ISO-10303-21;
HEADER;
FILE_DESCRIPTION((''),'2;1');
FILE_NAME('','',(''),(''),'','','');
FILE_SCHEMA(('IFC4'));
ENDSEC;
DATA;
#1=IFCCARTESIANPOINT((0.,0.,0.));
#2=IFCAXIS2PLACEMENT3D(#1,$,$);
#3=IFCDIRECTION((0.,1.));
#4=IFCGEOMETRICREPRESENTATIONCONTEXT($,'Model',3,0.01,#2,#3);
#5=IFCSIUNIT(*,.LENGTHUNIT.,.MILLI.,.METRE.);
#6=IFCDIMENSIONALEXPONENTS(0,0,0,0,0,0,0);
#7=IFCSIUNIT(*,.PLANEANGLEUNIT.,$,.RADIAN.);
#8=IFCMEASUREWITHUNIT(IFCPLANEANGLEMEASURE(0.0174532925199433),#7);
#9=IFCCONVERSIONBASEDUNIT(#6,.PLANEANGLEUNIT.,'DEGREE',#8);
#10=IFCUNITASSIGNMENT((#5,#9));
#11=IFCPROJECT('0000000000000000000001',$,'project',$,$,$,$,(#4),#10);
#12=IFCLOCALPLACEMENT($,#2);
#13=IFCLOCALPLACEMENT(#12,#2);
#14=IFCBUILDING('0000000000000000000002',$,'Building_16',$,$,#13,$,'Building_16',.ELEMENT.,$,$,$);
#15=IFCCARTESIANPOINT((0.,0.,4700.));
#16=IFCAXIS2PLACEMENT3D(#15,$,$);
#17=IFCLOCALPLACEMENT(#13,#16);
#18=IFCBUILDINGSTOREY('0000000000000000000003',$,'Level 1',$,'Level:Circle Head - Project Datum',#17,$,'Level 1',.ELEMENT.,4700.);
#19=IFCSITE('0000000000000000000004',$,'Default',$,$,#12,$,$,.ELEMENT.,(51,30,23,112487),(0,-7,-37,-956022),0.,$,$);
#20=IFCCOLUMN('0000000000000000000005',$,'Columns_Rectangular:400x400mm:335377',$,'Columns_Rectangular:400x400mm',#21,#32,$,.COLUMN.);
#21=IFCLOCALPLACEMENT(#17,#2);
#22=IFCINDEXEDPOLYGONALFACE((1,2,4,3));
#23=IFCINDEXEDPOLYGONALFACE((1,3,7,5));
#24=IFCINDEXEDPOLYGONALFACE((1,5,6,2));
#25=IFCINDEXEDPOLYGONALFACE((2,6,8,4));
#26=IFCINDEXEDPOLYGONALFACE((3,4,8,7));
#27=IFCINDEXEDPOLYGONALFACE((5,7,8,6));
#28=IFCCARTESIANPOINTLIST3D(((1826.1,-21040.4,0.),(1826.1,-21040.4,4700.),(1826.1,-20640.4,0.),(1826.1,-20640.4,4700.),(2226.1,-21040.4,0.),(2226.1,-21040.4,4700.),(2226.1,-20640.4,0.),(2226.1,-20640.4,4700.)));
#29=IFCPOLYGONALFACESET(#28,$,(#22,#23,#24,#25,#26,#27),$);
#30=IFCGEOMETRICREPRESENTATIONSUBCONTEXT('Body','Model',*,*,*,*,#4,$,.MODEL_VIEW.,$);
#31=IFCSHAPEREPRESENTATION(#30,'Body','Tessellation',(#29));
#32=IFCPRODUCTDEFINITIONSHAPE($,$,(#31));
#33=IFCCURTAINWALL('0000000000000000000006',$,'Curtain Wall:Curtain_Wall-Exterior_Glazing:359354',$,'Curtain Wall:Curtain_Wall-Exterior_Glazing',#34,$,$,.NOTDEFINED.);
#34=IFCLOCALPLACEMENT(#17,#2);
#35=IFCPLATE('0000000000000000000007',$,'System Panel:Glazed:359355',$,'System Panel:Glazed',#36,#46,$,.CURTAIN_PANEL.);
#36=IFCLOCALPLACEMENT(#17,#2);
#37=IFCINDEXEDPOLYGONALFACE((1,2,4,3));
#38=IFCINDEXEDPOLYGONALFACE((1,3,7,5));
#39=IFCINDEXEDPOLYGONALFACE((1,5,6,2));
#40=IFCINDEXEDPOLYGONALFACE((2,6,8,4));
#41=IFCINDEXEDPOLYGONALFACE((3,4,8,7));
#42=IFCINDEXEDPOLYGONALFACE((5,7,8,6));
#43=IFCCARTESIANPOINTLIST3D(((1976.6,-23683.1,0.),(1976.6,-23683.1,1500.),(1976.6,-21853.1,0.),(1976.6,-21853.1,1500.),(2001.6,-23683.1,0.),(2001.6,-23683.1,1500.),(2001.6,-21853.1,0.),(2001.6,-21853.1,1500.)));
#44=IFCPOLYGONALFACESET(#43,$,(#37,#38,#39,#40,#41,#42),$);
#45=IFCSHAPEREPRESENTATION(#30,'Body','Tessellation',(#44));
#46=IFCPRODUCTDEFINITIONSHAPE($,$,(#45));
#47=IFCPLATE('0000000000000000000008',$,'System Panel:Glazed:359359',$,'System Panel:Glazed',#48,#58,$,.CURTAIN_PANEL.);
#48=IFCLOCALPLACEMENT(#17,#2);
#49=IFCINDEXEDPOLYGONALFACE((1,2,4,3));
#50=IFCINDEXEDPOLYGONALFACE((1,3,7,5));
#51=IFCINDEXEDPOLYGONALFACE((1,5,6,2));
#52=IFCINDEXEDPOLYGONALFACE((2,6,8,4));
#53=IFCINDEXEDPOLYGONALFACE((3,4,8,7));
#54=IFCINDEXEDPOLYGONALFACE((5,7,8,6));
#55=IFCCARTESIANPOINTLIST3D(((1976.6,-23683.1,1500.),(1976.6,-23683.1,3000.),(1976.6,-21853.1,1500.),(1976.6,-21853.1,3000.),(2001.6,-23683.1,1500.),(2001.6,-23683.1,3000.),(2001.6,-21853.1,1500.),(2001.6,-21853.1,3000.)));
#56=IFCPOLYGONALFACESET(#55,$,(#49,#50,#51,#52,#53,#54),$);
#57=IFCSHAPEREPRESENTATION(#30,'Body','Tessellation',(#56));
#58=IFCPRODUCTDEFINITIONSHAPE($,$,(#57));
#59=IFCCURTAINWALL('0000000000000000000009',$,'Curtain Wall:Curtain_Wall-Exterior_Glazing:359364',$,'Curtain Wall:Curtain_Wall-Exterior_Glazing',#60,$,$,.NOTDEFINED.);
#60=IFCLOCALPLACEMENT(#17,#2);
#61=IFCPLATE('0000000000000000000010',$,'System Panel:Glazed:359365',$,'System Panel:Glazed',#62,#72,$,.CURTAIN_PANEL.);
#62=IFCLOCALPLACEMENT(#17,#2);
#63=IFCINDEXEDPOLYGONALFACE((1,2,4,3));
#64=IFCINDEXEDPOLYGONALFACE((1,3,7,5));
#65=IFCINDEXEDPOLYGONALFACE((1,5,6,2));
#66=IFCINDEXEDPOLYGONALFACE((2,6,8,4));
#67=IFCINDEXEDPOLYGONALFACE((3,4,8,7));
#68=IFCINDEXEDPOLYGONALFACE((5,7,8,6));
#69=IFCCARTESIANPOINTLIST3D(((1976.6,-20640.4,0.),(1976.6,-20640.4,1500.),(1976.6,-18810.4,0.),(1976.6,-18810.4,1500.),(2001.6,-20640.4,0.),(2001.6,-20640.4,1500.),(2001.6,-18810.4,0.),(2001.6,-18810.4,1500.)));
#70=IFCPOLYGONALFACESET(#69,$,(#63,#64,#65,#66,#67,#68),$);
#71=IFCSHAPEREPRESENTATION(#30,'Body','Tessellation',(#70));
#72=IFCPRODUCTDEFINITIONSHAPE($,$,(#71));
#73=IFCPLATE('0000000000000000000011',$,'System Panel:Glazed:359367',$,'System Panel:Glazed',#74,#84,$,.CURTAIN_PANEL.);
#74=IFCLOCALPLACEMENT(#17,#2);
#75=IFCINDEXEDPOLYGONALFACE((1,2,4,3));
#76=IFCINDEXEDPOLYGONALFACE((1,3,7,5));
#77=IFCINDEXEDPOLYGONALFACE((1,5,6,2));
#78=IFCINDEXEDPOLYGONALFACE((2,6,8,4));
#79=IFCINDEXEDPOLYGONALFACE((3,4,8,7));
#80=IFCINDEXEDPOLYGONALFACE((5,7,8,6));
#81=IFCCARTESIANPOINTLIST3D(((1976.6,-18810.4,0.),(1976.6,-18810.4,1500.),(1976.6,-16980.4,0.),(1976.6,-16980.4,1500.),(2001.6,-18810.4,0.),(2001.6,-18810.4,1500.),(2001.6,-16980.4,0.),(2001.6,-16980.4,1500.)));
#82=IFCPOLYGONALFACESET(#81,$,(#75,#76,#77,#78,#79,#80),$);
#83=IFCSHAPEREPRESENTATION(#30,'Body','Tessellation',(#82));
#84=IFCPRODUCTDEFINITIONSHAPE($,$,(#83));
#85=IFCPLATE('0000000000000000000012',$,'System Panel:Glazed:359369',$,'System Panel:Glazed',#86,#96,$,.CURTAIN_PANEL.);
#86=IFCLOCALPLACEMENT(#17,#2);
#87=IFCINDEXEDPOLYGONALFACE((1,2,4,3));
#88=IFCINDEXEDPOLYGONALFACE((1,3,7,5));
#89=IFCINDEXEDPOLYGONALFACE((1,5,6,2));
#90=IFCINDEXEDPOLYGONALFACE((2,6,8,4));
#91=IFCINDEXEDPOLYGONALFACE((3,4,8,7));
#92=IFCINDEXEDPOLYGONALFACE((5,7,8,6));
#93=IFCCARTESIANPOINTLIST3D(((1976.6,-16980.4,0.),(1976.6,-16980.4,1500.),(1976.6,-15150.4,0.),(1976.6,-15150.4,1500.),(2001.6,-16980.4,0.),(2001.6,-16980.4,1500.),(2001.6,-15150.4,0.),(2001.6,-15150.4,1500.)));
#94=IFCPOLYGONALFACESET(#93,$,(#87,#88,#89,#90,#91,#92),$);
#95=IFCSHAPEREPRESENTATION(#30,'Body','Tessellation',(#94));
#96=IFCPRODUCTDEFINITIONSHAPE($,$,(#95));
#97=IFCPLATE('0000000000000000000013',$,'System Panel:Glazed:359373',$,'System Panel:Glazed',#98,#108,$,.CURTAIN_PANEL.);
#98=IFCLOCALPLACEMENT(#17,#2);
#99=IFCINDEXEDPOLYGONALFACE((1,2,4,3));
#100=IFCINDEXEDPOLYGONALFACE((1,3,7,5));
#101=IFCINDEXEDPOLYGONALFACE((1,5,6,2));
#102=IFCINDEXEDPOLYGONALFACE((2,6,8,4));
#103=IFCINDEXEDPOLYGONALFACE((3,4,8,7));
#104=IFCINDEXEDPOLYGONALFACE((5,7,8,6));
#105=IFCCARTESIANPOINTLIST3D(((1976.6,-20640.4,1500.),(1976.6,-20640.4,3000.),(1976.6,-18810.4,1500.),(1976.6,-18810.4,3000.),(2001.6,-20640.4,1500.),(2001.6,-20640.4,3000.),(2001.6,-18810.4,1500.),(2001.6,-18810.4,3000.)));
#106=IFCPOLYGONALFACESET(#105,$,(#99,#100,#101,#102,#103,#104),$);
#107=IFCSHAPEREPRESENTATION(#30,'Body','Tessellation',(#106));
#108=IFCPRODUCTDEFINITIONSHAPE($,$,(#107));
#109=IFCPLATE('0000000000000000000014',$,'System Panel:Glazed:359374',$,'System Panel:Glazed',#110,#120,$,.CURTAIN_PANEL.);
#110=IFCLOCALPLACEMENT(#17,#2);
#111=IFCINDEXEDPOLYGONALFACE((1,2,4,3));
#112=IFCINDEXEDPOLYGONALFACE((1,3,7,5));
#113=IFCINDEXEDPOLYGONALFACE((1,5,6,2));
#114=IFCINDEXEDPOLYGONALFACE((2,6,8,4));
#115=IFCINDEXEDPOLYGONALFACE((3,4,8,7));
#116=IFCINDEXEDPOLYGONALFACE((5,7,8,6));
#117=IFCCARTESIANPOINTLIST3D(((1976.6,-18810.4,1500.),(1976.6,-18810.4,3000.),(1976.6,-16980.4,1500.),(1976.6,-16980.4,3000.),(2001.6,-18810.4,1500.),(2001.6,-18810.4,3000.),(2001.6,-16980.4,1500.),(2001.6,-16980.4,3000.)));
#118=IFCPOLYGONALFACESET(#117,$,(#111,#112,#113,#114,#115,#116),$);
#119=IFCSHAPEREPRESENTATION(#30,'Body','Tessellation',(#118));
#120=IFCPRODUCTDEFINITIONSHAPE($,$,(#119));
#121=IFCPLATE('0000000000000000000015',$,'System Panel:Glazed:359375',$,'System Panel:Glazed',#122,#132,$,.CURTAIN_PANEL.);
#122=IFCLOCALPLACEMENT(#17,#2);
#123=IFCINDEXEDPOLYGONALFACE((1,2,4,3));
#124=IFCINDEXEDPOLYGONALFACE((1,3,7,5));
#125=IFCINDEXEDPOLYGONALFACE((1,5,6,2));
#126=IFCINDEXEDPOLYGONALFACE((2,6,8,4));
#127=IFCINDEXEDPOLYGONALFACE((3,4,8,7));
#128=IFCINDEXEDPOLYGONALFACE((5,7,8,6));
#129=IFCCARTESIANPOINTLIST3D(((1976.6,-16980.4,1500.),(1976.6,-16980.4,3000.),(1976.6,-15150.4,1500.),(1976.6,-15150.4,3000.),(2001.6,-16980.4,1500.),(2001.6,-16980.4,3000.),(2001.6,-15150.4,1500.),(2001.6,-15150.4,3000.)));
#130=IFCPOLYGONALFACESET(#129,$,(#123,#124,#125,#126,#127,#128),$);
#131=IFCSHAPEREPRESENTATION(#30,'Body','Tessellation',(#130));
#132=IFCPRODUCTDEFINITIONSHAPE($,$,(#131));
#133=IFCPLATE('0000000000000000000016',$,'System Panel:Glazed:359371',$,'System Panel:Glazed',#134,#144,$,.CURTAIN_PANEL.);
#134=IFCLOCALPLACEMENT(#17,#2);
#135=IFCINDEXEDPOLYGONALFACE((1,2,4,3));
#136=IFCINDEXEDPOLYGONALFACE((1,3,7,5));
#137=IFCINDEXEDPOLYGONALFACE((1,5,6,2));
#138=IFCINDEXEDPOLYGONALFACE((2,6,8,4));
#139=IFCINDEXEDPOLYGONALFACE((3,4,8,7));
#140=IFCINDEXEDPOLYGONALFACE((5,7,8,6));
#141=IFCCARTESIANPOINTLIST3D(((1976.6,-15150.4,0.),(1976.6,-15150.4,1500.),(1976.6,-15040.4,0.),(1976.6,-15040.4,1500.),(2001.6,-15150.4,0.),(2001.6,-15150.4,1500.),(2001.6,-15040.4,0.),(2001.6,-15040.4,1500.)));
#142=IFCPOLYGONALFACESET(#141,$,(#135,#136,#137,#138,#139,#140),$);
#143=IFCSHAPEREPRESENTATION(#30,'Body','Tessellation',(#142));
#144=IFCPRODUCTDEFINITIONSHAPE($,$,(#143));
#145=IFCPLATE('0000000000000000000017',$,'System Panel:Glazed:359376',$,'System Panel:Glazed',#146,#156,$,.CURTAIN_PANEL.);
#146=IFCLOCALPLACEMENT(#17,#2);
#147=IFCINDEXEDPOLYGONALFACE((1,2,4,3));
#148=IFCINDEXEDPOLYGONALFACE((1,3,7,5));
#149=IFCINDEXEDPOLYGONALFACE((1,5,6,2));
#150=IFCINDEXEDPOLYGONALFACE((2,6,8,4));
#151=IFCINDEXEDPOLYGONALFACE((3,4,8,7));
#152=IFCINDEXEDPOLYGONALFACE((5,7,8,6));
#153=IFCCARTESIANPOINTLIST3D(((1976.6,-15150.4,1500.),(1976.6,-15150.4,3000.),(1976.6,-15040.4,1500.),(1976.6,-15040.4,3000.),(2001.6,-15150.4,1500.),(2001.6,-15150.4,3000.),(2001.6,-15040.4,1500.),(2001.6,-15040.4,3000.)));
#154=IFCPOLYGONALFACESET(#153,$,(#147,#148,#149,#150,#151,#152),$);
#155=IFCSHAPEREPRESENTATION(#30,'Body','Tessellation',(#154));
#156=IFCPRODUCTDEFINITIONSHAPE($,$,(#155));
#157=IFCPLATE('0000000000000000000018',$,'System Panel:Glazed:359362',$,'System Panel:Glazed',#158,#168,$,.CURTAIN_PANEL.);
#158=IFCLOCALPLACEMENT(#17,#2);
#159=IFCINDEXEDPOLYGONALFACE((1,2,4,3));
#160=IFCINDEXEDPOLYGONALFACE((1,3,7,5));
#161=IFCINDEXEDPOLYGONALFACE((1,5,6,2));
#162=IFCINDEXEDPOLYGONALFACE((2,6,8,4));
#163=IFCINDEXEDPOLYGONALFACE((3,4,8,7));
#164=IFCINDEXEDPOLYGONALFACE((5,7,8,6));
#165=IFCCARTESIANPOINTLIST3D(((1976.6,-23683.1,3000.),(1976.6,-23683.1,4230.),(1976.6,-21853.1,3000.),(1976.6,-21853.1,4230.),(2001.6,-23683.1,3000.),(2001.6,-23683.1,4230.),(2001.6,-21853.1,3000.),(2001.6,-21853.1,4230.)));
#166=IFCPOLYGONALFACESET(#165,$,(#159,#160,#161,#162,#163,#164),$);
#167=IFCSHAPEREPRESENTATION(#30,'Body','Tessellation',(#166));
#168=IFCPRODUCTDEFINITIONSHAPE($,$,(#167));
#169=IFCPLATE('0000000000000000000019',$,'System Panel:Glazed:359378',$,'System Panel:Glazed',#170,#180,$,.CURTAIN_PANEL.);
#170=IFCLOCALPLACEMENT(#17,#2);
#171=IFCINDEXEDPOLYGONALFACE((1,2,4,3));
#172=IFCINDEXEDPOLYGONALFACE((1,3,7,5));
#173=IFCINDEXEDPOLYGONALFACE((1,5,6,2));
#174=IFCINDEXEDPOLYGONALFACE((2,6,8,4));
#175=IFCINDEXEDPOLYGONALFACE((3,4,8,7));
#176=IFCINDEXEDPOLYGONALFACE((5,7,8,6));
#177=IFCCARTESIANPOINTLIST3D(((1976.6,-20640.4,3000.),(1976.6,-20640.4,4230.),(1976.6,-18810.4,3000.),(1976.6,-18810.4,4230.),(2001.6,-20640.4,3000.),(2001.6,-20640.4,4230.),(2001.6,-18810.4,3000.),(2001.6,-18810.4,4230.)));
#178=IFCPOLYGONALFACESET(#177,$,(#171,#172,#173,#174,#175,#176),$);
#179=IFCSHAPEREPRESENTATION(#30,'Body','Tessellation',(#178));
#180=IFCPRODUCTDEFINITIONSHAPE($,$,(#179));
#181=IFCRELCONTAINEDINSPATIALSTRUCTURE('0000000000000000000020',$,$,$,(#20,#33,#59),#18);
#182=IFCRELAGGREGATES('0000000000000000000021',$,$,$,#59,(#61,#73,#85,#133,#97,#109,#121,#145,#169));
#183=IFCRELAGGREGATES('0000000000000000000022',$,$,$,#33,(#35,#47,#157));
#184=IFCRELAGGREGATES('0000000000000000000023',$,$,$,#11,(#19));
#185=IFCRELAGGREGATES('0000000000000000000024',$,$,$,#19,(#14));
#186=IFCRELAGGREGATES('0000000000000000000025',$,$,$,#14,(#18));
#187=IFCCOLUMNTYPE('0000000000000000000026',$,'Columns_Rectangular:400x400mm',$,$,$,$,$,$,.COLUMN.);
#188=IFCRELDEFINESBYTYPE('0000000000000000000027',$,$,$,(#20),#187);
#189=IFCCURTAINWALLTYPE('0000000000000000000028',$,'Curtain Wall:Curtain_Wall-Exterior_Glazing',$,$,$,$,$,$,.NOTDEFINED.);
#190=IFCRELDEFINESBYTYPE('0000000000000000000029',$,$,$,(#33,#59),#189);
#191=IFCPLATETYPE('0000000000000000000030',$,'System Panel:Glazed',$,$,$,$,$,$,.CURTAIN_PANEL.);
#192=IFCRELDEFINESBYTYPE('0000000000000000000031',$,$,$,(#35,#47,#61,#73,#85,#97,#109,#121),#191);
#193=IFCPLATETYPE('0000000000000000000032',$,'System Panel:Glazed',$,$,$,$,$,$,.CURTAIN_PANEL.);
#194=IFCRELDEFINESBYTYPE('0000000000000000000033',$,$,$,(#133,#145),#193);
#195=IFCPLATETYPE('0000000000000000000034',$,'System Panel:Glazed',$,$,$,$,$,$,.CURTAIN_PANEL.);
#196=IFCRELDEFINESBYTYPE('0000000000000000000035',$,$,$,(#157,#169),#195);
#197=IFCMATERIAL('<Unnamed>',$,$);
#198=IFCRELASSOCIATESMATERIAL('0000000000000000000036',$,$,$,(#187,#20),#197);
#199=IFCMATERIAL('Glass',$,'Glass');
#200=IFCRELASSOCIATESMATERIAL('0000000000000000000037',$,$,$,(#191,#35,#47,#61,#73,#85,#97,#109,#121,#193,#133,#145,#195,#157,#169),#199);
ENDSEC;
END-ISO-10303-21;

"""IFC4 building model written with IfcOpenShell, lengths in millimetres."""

from ifc_helpers import new_model, entity, si_unit, converted_unit, direction, frame, origin, place, context, subcontext, project, spatial, indexed_curve, outline, extrude, source, transform, mapped, material, type_object, type_shapes, element, aggregate, save


model = new_model("IFC4")

# Units and contexts
model_context = context("Model", 3, precision=0.01, world=origin(), true_north=direction((0.0, 1.0)))
body_context = subcontext(model_context, "Body", "Model", "MODEL_VIEW")
ifc_project = project(units=[si_unit("LENGTHUNIT", "METRE", prefix="MILLI"), converted_unit("PLANEANGLEUNIT", "DEGREE", entity("IfcPlaneAngleMeasure", 0.0174532925199433), si_unit("PLANEANGLEUNIT", "RADIAN"), dimensions=[0, 0, 0, 0, 0, 0, 0])], contexts=[model_context])

# Site, building, storey
site_placement = place(None, origin())
site = spatial("IfcSite", under=ifc_project, at=site_placement, Name="Default", CompositionType="ELEMENT", RefLatitude=(51, 30, 23, 112487), RefLongitude=(0, -7, -37, -956022), RefElevation=0.0)
building_placement = place(site_placement, origin())
building = spatial("IfcBuilding", under=site, at=building_placement, Name="Building_16", LongName="Building_16", CompositionType="ELEMENT")
storey_placement = place(building_placement, frame((0.0, 0.0, 4700.0)))
storey = spatial("IfcBuildingStorey", under=building, at=storey_placement, Name="Level 1", ObjectType="Level:Circle Head - Project Datum", LongName="Level 1", CompositionType="ELEMENT", Elevation=4700.0)

# Column
ifc_material_1 = material(Name="<Unnamed>")
column_type = type_object("IfcColumnType", Name="Columns_Rectangular:400x400mm", PredefinedType="COLUMN", material=ifc_material_1)
shared_shape_1 = source(origin(), body_context, "Body", "SweptSolid", [
    extrude(outline(indexed_curve([(-200.0, -200.0), (200.0, -200.0), (200.0, 200.0), (-200.0, 200.0), (-200.0, -200.0)], self_intersect=False)), frame((0.0, 0.0, 4700.0), z_axis=(0.0, 0.0, 1.0), x_axis=(-1.0, 0.0, 0.0)), (0.0, 0.0, 1.0), 4700.0),
])
type_shapes(column_type, [shared_shape_1])
column_placement = place(storey_placement, frame((2026.1, -20840.4, -4700.0)))
element("IfcColumn", 1, at=column_placement, inside=storey, type_object=column_type, material=ifc_material_1, Name="Columns_Rectangular:400x400mm:335377", ObjectType="Columns_Rectangular:400x400mm", PredefinedType="COLUMN", context=body_context, shape_type="MappedRepresentation", body=[
    mapped(shared_shape_1, transform((0.0, 0.0, 0.0), scale=1.0)),
])

# Curtain walls, plates
curtain_wall_type = type_object("IfcCurtainWallType", Name="Curtain Wall:Curtain_Wall-Exterior_Glazing", PredefinedType="NOTDEFINED")
curtain_wall_1_placement = place(storey_placement, frame((0.0, 0.0, -4700.0)))
curtain_wall_1 = element("IfcCurtainWall", 2, at=curtain_wall_1_placement, inside=storey, type_object=curtain_wall_type, Name="Curtain Wall:Curtain_Wall-Exterior_Glazing:359354", ObjectType="Curtain Wall:Curtain_Wall-Exterior_Glazing", PredefinedType="NOTDEFINED")
ifc_material_2 = material(Name="Glass", Category="Glass")
plate_type_1 = type_object("IfcPlateType", Name="System Panel:Glazed", PredefinedType="CURTAIN_PANEL", material=ifc_material_2)
shared_shape_2 = source(origin(), body_context, "Body", "SweptSolid", [
    extrude(outline(indexed_curve([(-12.5, -915.0), (12.5, -915.0), (12.5, 915.0), (-12.5, 915.0), (-12.5, -915.0)], self_intersect=False)), frame((0.0, 37.0, 0.0), z_axis=(0.0, 0.0, 1.0), x_axis=(0.0, 1.0, 0.0)), (0.0, 0.0, 1.0), 1500.0),
])
type_shapes(plate_type_1, [shared_shape_2])
plate_1_placement = place(curtain_wall_1_placement, frame((2026.1, -22768.1, 4700.0), z_axis=(0.0, 0.0, 1.0), x_axis=(0.0, 1.0, 0.0)))
plate_1 = element("IfcPlate", 3, at=plate_1_placement, type_object=plate_type_1, material=ifc_material_2, Name="System Panel:Glazed:359355", ObjectType="System Panel:Glazed", PredefinedType="CURTAIN_PANEL", context=body_context, shape_type="MappedRepresentation", body=[
    mapped(shared_shape_2, transform((0.0, 0.0, 0.0), scale=1.0)),
])
plate_2_placement = place(curtain_wall_1_placement, frame((2026.1, -22768.1, 6200.0), z_axis=(0.0, 0.0, 1.0), x_axis=(0.0, 1.0, 0.0)))
plate_2 = element("IfcPlate", 4, at=plate_2_placement, type_object=plate_type_1, material=ifc_material_2, Name="System Panel:Glazed:359359", ObjectType="System Panel:Glazed", PredefinedType="CURTAIN_PANEL", context=body_context, shape_type="MappedRepresentation", body=[
    mapped(shared_shape_2, transform((0.0, 0.0, 0.0), scale=1.0)),
])
curtain_wall_2_placement = place(storey_placement, frame((0.0, 0.0, -4700.0)))
curtain_wall_2 = element("IfcCurtainWall", 5, at=curtain_wall_2_placement, inside=storey, type_object=curtain_wall_type, Name="Curtain Wall:Curtain_Wall-Exterior_Glazing:359364", ObjectType="Curtain Wall:Curtain_Wall-Exterior_Glazing", PredefinedType="NOTDEFINED")
plate_3_placement = place(curtain_wall_2_placement, frame((2026.1, -19725.4, 4700.0), z_axis=(0.0, 0.0, 1.0), x_axis=(0.0, 1.0, 0.0)))
plate_3 = element("IfcPlate", 6, at=plate_3_placement, type_object=plate_type_1, material=ifc_material_2, Name="System Panel:Glazed:359365", ObjectType="System Panel:Glazed", PredefinedType="CURTAIN_PANEL", context=body_context, shape_type="MappedRepresentation", body=[
    mapped(shared_shape_2, transform((0.0, 0.0, 0.0), scale=1.0)),
])
plate_4_placement = place(curtain_wall_2_placement, frame((2026.1, -17895.4, 4700.0), z_axis=(0.0, 0.0, 1.0), x_axis=(0.0, 1.0, 0.0)))
plate_4 = element("IfcPlate", 7, at=plate_4_placement, type_object=plate_type_1, material=ifc_material_2, Name="System Panel:Glazed:359367", ObjectType="System Panel:Glazed", PredefinedType="CURTAIN_PANEL", context=body_context, shape_type="MappedRepresentation", body=[
    mapped(shared_shape_2, transform((0.0, 0.0, 0.0), scale=1.0)),
])
plate_5_placement = place(curtain_wall_2_placement, frame((2026.1, -16065.4, 4700.0), z_axis=(0.0, 0.0, 1.0), x_axis=(0.0, 1.0, 0.0)))
plate_5 = element("IfcPlate", 8, at=plate_5_placement, type_object=plate_type_1, material=ifc_material_2, Name="System Panel:Glazed:359369", ObjectType="System Panel:Glazed", PredefinedType="CURTAIN_PANEL", context=body_context, shape_type="MappedRepresentation", body=[
    mapped(shared_shape_2, transform((0.0, 0.0, 0.0), scale=1.0)),
])
plate_6_placement = place(curtain_wall_2_placement, frame((2026.1, -19725.4, 6200.0), z_axis=(0.0, 0.0, 1.0), x_axis=(0.0, 1.0, 0.0)))
plate_6 = element("IfcPlate", 9, at=plate_6_placement, type_object=plate_type_1, material=ifc_material_2, Name="System Panel:Glazed:359373", ObjectType="System Panel:Glazed", PredefinedType="CURTAIN_PANEL", context=body_context, shape_type="MappedRepresentation", body=[
    mapped(shared_shape_2, transform((0.0, 0.0, 0.0), scale=1.0)),
])
plate_7_placement = place(curtain_wall_2_placement, frame((2026.1, -17895.4, 6200.0), z_axis=(0.0, 0.0, 1.0), x_axis=(0.0, 1.0, 0.0)))
plate_7 = element("IfcPlate", 10, at=plate_7_placement, type_object=plate_type_1, material=ifc_material_2, Name="System Panel:Glazed:359374", ObjectType="System Panel:Glazed", PredefinedType="CURTAIN_PANEL", context=body_context, shape_type="MappedRepresentation", body=[
    mapped(shared_shape_2, transform((0.0, 0.0, 0.0), scale=1.0)),
])
plate_8_placement = place(curtain_wall_2_placement, frame((2026.1, -16065.4, 6200.0), z_axis=(0.0, 0.0, 1.0), x_axis=(0.0, 1.0, 0.0)))
plate_8 = element("IfcPlate", 11, at=plate_8_placement, type_object=plate_type_1, material=ifc_material_2, Name="System Panel:Glazed:359375", ObjectType="System Panel:Glazed", PredefinedType="CURTAIN_PANEL", context=body_context, shape_type="MappedRepresentation", body=[
    mapped(shared_shape_2, transform((0.0, 0.0, 0.0), scale=1.0)),
])
plate_type_2 = type_object("IfcPlateType", Name="System Panel:Glazed", PredefinedType="CURTAIN_PANEL", material=ifc_material_2)
shared_shape_3 = source(origin(), body_context, "Body", "SweptSolid", [
    extrude(outline(indexed_curve([(-12.5, -55.0), (12.5, -55.0), (12.5, 55.0), (-12.5, 55.0), (-12.5, -55.0)], self_intersect=False)), frame((0.0, 37.0, 0.0), z_axis=(0.0, 0.0, 1.0), x_axis=(0.0, 1.0, 0.0)), (0.0, 0.0, 1.0), 1500.0),
])
type_shapes(plate_type_2, [shared_shape_3])
plate_9_placement = place(curtain_wall_2_placement, frame((2026.1, -15095.4, 4700.0), z_axis=(0.0, 0.0, 1.0), x_axis=(0.0, 1.0, 0.0)))
plate_9 = element("IfcPlate", 12, at=plate_9_placement, type_object=plate_type_2, material=ifc_material_2, Name="System Panel:Glazed:359371", ObjectType="System Panel:Glazed", PredefinedType="CURTAIN_PANEL", context=body_context, shape_type="MappedRepresentation", body=[
    mapped(shared_shape_3, transform((0.0, 0.0, 0.0), scale=1.0)),
])
plate_10_placement = place(curtain_wall_2_placement, frame((2026.1, -15095.4, 6200.0), z_axis=(0.0, 0.0, 1.0), x_axis=(0.0, 1.0, 0.0)))
plate_10 = element("IfcPlate", 13, at=plate_10_placement, type_object=plate_type_2, material=ifc_material_2, Name="System Panel:Glazed:359376", ObjectType="System Panel:Glazed", PredefinedType="CURTAIN_PANEL", context=body_context, shape_type="MappedRepresentation", body=[
    mapped(shared_shape_3, transform((0.0, 0.0, 0.0), scale=1.0)),
])

# Plates
plate_type_3 = type_object("IfcPlateType", Name="System Panel:Glazed", PredefinedType="CURTAIN_PANEL", material=ifc_material_2)
shared_shape_4 = source(origin(), body_context, "Body", "SweptSolid", [
    extrude(outline(indexed_curve([(-12.5, -915.0), (12.5, -915.0), (12.5, 915.0), (-12.5, 915.0), (-12.5, -915.0)], self_intersect=False)), frame((0.0, 37.0, 0.0), z_axis=(0.0, 0.0, 1.0), x_axis=(0.0, 1.0, 0.0)), (0.0, 0.0, 1.0), 1230.0),
])
type_shapes(plate_type_3, [shared_shape_4])
plate_11_placement = place(curtain_wall_1_placement, frame((2026.1, -22768.1, 7700.0), z_axis=(0.0, 0.0, 1.0), x_axis=(0.0, 1.0, 0.0)))
plate_11 = element("IfcPlate", 14, at=plate_11_placement, type_object=plate_type_3, material=ifc_material_2, Name="System Panel:Glazed:359362", ObjectType="System Panel:Glazed", PredefinedType="CURTAIN_PANEL", context=body_context, shape_type="MappedRepresentation", body=[
    mapped(shared_shape_4, transform((0.0, 0.0, 0.0), scale=1.0)),
])
plate_12_placement = place(curtain_wall_2_placement, frame((2026.1, -19725.4, 7700.0), z_axis=(0.0, 0.0, 1.0), x_axis=(0.0, 1.0, 0.0)))
plate_12 = element("IfcPlate", 15, at=plate_12_placement, type_object=plate_type_3, material=ifc_material_2, Name="System Panel:Glazed:359378", ObjectType="System Panel:Glazed", PredefinedType="CURTAIN_PANEL", context=body_context, shape_type="MappedRepresentation", body=[
    mapped(shared_shape_4, transform((0.0, 0.0, 0.0), scale=1.0)),
])
aggregate(curtain_wall_2, [plate_3, plate_4, plate_5, plate_9, plate_6, plate_7, plate_8, plate_10, plate_12])

aggregate(curtain_wall_1, [plate_1, plate_2, plate_11])

save(model, "model.ifc")
